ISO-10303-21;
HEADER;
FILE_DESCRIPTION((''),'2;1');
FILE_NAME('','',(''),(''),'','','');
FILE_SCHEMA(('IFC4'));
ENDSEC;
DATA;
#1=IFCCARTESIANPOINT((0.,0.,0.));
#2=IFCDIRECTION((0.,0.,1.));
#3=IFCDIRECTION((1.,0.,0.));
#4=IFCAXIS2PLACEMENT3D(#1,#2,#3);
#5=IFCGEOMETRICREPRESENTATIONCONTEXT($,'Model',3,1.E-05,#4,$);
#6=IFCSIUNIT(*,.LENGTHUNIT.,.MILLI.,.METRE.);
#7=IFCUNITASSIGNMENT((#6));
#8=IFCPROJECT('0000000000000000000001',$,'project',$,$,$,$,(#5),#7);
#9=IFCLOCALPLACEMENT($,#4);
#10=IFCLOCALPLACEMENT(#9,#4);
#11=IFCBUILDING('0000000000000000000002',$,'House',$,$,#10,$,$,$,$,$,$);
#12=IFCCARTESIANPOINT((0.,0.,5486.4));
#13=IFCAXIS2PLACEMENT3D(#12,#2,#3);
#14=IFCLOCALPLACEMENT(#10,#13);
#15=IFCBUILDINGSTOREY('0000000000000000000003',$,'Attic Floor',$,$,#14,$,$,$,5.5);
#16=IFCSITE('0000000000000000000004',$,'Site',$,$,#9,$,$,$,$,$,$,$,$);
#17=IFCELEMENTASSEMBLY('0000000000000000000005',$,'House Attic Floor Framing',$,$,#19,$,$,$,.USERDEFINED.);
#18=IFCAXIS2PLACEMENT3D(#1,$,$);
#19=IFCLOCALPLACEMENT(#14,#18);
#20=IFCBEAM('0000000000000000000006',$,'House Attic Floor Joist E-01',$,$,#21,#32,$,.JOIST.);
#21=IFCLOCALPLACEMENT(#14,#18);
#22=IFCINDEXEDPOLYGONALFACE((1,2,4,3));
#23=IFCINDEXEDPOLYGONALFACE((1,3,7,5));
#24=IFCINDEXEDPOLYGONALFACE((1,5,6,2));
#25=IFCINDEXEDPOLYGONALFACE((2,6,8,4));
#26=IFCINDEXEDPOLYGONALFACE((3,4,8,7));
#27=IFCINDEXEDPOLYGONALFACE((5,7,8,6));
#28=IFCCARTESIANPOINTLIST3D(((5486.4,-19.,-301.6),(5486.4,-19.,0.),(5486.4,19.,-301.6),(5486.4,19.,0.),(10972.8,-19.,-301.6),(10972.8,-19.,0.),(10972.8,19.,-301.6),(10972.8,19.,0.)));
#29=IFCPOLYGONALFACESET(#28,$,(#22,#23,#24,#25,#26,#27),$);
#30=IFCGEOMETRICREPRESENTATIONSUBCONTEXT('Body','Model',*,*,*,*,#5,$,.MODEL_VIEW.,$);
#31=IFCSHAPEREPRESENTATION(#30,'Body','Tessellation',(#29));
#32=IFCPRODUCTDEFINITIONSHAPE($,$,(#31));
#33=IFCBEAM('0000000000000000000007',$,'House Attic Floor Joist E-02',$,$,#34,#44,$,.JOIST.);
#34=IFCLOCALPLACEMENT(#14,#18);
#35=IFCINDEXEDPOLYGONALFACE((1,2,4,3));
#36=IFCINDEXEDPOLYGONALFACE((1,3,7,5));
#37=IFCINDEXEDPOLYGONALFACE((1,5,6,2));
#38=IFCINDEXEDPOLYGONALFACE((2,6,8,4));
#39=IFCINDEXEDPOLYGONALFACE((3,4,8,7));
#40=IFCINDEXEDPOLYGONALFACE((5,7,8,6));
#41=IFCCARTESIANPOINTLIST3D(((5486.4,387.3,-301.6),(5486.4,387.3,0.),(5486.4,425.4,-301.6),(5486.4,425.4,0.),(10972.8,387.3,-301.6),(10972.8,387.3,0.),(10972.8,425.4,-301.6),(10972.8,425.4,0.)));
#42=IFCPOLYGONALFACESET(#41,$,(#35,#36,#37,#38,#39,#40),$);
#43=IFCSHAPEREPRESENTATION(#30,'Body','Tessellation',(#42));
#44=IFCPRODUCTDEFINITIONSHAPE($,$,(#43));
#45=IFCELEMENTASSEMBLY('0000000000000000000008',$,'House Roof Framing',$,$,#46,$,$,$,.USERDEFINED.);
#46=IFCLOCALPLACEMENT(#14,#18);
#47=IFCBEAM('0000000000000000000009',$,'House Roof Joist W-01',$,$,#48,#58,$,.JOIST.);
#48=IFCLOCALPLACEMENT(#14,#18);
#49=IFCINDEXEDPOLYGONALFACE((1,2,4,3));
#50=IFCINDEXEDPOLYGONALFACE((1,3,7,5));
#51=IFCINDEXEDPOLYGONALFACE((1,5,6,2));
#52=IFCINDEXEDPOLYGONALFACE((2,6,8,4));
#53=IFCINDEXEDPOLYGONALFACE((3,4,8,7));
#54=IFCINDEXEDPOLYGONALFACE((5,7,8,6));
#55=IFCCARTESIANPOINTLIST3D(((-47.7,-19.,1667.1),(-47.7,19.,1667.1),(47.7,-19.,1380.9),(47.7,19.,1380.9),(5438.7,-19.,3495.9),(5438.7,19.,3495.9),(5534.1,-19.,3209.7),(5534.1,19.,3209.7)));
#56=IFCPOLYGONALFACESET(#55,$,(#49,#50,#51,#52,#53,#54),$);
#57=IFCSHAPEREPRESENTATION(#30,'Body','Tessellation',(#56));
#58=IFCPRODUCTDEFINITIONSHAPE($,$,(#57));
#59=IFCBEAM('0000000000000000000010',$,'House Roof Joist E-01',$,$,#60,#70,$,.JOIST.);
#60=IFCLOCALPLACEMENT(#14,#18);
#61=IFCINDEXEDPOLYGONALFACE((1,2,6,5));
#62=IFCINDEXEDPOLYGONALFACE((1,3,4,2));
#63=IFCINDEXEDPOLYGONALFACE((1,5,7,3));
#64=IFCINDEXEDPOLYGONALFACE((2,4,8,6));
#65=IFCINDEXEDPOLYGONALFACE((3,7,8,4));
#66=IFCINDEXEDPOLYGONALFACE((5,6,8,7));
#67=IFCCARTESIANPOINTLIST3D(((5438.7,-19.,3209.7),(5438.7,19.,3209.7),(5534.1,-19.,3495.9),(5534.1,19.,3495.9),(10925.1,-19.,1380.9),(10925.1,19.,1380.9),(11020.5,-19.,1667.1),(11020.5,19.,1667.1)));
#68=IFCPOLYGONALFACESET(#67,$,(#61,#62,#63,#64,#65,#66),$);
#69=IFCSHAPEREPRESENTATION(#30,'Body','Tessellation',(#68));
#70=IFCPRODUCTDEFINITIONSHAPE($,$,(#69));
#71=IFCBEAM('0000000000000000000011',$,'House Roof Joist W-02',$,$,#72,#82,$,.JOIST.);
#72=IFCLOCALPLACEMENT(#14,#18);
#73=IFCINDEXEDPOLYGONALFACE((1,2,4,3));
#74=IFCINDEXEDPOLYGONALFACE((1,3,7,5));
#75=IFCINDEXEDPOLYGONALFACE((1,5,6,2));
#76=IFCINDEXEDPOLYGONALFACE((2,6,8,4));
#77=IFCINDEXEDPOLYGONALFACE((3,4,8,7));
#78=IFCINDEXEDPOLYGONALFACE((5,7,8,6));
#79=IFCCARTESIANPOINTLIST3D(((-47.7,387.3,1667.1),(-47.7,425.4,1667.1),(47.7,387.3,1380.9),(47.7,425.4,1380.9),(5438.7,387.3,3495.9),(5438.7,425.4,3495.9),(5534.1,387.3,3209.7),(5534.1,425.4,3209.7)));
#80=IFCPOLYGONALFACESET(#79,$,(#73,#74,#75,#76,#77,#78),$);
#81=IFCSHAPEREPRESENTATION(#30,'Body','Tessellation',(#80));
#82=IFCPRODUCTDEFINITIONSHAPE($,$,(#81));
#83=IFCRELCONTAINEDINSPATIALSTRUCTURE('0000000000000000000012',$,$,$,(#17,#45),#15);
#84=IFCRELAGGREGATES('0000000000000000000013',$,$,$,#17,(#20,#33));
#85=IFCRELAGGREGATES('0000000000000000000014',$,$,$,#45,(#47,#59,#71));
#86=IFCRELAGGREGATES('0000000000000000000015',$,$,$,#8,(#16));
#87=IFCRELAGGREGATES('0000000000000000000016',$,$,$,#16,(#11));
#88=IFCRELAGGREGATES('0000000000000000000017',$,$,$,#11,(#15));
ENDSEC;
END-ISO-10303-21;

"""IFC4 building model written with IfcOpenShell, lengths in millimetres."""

from ifc_helpers import new_model, si_unit, frame, origin_with_axes, origin_2d, place, context, subcontext, project, spatial, rectangle, extrude, element, aggregate, save


model = new_model("IFC4")

# Units and contexts
model_context = context("Model", 3, precision=1e-05, world=origin_with_axes())
body_context = subcontext(model_context, "Body", "Model", "MODEL_VIEW")
ifc_project = project(units=[si_unit("LENGTHUNIT", "METRE", prefix="MILLI")], contexts=[model_context])

# Site, building, storey
site_placement = place(None, origin_with_axes())
site = spatial("IfcSite", under=ifc_project, at=site_placement, Name="Site")
building_placement = place(site_placement, origin_with_axes())
building = spatial("IfcBuilding", under=site, at=building_placement, Name="House")
storey_placement = place(building_placement, frame((0.0, 0.0, 5486.4), z_axis=(0.0, 0.0, 1.0), x_axis=(1.0, 0.0, 0.0)))
storey = spatial("IfcBuildingStorey", under=building, at=storey_placement, Name="Attic Floor", Elevation=5.5)

# Element assemblies, beams
assembly_1_placement = place(storey_placement, frame((0.0, 0.0, -5486.4), z_axis=(0.0, 0.0, 1.0), x_axis=(1.0, 0.0, 0.0)))
assembly_1 = element("IfcElementAssembly", 1, at=assembly_1_placement, inside=storey, Name="House Attic Floor Framing", PredefinedType="USERDEFINED")
beam_1_placement = place(assembly_1_placement, frame((5486.4, 0.0, 5335.6), z_axis=(1.0, 0.0, 0.0), x_axis=(0.0, 1.0, 0.0)))
beam_1 = element("IfcBeam", 2, at=beam_1_placement, Name="House Attic Floor Joist E-01", PredefinedType="JOIST", context=body_context, shape_type="SweptSolid", body=[
    extrude(rectangle(XDim=38.1, YDim=301.6, at=origin_2d()), origin_with_axes(), (0.0, 0.0, 1.0), 5486.4),
])
beam_2_placement = place(assembly_1_placement, frame((5486.4, 406.4, 5335.6), z_axis=(1.0, 0.0, 0.0), x_axis=(0.0, 1.0, 0.0)))
beam_2 = element("IfcBeam", 3, at=beam_2_placement, Name="House Attic Floor Joist E-02", PredefinedType="JOIST", context=body_context, shape_type="SweptSolid", body=[
    extrude(rectangle(XDim=38.1, YDim=301.6, at=origin_2d()), origin_with_axes(), (0.0, 0.0, 1.0), 5486.4),
])
aggregate(assembly_1, [beam_1, beam_2])
assembly_2_placement = place(storey_placement, frame((0.0, 0.0, -5486.4), z_axis=(0.0, 0.0, 1.0), x_axis=(1.0, 0.0, 0.0)))
assembly_2 = element("IfcElementAssembly", 4, at=assembly_2_placement, inside=storey, Name="House Roof Framing", PredefinedType="USERDEFINED")
beam_3_placement = place(assembly_2_placement, frame((5486.4, 0.0, 8839.2), z_axis=(-0.948683, 0.0, -0.316228), x_axis=(0.0, 1.0, 0.0)))
beam_3 = element("IfcBeam", 5, at=beam_3_placement, Name="House Roof Joist W-01", PredefinedType="JOIST", context=body_context, shape_type="SweptSolid", body=[
    extrude(rectangle(XDim=38.1, YDim=301.6, at=origin_2d()), origin_with_axes(), (0.0, 0.0, 1.0), 5783.2),
])
beam_4_placement = place(assembly_2_placement, frame((5486.4, 0.0, 8839.2), z_axis=(0.948683, 0.0, -0.316228), x_axis=(0.0, 1.0, 0.0)))
beam_4 = element("IfcBeam", 6, at=beam_4_placement, Name="House Roof Joist E-01", PredefinedType="JOIST", context=body_context, shape_type="SweptSolid", body=[
    extrude(rectangle(XDim=38.1, YDim=301.6, at=origin_2d()), origin_with_axes(), (0.0, 0.0, 1.0), 5783.2),
])
beam_5_placement = place(assembly_2_placement, frame((5486.4, 406.4, 8839.2), z_axis=(-0.948683, 0.0, -0.316228), x_axis=(0.0, 1.0, 0.0)))
beam_5 = element("IfcBeam", 7, at=beam_5_placement, Name="House Roof Joist W-02", PredefinedType="JOIST", context=body_context, shape_type="SweptSolid", body=[
    extrude(rectangle(XDim=38.1, YDim=301.6, at=origin_2d()), origin_with_axes(), (0.0, 0.0, 1.0), 5783.2),
])
aggregate(assembly_2, [beam_3, beam_4, beam_5])

save(model, "model.ifc")
